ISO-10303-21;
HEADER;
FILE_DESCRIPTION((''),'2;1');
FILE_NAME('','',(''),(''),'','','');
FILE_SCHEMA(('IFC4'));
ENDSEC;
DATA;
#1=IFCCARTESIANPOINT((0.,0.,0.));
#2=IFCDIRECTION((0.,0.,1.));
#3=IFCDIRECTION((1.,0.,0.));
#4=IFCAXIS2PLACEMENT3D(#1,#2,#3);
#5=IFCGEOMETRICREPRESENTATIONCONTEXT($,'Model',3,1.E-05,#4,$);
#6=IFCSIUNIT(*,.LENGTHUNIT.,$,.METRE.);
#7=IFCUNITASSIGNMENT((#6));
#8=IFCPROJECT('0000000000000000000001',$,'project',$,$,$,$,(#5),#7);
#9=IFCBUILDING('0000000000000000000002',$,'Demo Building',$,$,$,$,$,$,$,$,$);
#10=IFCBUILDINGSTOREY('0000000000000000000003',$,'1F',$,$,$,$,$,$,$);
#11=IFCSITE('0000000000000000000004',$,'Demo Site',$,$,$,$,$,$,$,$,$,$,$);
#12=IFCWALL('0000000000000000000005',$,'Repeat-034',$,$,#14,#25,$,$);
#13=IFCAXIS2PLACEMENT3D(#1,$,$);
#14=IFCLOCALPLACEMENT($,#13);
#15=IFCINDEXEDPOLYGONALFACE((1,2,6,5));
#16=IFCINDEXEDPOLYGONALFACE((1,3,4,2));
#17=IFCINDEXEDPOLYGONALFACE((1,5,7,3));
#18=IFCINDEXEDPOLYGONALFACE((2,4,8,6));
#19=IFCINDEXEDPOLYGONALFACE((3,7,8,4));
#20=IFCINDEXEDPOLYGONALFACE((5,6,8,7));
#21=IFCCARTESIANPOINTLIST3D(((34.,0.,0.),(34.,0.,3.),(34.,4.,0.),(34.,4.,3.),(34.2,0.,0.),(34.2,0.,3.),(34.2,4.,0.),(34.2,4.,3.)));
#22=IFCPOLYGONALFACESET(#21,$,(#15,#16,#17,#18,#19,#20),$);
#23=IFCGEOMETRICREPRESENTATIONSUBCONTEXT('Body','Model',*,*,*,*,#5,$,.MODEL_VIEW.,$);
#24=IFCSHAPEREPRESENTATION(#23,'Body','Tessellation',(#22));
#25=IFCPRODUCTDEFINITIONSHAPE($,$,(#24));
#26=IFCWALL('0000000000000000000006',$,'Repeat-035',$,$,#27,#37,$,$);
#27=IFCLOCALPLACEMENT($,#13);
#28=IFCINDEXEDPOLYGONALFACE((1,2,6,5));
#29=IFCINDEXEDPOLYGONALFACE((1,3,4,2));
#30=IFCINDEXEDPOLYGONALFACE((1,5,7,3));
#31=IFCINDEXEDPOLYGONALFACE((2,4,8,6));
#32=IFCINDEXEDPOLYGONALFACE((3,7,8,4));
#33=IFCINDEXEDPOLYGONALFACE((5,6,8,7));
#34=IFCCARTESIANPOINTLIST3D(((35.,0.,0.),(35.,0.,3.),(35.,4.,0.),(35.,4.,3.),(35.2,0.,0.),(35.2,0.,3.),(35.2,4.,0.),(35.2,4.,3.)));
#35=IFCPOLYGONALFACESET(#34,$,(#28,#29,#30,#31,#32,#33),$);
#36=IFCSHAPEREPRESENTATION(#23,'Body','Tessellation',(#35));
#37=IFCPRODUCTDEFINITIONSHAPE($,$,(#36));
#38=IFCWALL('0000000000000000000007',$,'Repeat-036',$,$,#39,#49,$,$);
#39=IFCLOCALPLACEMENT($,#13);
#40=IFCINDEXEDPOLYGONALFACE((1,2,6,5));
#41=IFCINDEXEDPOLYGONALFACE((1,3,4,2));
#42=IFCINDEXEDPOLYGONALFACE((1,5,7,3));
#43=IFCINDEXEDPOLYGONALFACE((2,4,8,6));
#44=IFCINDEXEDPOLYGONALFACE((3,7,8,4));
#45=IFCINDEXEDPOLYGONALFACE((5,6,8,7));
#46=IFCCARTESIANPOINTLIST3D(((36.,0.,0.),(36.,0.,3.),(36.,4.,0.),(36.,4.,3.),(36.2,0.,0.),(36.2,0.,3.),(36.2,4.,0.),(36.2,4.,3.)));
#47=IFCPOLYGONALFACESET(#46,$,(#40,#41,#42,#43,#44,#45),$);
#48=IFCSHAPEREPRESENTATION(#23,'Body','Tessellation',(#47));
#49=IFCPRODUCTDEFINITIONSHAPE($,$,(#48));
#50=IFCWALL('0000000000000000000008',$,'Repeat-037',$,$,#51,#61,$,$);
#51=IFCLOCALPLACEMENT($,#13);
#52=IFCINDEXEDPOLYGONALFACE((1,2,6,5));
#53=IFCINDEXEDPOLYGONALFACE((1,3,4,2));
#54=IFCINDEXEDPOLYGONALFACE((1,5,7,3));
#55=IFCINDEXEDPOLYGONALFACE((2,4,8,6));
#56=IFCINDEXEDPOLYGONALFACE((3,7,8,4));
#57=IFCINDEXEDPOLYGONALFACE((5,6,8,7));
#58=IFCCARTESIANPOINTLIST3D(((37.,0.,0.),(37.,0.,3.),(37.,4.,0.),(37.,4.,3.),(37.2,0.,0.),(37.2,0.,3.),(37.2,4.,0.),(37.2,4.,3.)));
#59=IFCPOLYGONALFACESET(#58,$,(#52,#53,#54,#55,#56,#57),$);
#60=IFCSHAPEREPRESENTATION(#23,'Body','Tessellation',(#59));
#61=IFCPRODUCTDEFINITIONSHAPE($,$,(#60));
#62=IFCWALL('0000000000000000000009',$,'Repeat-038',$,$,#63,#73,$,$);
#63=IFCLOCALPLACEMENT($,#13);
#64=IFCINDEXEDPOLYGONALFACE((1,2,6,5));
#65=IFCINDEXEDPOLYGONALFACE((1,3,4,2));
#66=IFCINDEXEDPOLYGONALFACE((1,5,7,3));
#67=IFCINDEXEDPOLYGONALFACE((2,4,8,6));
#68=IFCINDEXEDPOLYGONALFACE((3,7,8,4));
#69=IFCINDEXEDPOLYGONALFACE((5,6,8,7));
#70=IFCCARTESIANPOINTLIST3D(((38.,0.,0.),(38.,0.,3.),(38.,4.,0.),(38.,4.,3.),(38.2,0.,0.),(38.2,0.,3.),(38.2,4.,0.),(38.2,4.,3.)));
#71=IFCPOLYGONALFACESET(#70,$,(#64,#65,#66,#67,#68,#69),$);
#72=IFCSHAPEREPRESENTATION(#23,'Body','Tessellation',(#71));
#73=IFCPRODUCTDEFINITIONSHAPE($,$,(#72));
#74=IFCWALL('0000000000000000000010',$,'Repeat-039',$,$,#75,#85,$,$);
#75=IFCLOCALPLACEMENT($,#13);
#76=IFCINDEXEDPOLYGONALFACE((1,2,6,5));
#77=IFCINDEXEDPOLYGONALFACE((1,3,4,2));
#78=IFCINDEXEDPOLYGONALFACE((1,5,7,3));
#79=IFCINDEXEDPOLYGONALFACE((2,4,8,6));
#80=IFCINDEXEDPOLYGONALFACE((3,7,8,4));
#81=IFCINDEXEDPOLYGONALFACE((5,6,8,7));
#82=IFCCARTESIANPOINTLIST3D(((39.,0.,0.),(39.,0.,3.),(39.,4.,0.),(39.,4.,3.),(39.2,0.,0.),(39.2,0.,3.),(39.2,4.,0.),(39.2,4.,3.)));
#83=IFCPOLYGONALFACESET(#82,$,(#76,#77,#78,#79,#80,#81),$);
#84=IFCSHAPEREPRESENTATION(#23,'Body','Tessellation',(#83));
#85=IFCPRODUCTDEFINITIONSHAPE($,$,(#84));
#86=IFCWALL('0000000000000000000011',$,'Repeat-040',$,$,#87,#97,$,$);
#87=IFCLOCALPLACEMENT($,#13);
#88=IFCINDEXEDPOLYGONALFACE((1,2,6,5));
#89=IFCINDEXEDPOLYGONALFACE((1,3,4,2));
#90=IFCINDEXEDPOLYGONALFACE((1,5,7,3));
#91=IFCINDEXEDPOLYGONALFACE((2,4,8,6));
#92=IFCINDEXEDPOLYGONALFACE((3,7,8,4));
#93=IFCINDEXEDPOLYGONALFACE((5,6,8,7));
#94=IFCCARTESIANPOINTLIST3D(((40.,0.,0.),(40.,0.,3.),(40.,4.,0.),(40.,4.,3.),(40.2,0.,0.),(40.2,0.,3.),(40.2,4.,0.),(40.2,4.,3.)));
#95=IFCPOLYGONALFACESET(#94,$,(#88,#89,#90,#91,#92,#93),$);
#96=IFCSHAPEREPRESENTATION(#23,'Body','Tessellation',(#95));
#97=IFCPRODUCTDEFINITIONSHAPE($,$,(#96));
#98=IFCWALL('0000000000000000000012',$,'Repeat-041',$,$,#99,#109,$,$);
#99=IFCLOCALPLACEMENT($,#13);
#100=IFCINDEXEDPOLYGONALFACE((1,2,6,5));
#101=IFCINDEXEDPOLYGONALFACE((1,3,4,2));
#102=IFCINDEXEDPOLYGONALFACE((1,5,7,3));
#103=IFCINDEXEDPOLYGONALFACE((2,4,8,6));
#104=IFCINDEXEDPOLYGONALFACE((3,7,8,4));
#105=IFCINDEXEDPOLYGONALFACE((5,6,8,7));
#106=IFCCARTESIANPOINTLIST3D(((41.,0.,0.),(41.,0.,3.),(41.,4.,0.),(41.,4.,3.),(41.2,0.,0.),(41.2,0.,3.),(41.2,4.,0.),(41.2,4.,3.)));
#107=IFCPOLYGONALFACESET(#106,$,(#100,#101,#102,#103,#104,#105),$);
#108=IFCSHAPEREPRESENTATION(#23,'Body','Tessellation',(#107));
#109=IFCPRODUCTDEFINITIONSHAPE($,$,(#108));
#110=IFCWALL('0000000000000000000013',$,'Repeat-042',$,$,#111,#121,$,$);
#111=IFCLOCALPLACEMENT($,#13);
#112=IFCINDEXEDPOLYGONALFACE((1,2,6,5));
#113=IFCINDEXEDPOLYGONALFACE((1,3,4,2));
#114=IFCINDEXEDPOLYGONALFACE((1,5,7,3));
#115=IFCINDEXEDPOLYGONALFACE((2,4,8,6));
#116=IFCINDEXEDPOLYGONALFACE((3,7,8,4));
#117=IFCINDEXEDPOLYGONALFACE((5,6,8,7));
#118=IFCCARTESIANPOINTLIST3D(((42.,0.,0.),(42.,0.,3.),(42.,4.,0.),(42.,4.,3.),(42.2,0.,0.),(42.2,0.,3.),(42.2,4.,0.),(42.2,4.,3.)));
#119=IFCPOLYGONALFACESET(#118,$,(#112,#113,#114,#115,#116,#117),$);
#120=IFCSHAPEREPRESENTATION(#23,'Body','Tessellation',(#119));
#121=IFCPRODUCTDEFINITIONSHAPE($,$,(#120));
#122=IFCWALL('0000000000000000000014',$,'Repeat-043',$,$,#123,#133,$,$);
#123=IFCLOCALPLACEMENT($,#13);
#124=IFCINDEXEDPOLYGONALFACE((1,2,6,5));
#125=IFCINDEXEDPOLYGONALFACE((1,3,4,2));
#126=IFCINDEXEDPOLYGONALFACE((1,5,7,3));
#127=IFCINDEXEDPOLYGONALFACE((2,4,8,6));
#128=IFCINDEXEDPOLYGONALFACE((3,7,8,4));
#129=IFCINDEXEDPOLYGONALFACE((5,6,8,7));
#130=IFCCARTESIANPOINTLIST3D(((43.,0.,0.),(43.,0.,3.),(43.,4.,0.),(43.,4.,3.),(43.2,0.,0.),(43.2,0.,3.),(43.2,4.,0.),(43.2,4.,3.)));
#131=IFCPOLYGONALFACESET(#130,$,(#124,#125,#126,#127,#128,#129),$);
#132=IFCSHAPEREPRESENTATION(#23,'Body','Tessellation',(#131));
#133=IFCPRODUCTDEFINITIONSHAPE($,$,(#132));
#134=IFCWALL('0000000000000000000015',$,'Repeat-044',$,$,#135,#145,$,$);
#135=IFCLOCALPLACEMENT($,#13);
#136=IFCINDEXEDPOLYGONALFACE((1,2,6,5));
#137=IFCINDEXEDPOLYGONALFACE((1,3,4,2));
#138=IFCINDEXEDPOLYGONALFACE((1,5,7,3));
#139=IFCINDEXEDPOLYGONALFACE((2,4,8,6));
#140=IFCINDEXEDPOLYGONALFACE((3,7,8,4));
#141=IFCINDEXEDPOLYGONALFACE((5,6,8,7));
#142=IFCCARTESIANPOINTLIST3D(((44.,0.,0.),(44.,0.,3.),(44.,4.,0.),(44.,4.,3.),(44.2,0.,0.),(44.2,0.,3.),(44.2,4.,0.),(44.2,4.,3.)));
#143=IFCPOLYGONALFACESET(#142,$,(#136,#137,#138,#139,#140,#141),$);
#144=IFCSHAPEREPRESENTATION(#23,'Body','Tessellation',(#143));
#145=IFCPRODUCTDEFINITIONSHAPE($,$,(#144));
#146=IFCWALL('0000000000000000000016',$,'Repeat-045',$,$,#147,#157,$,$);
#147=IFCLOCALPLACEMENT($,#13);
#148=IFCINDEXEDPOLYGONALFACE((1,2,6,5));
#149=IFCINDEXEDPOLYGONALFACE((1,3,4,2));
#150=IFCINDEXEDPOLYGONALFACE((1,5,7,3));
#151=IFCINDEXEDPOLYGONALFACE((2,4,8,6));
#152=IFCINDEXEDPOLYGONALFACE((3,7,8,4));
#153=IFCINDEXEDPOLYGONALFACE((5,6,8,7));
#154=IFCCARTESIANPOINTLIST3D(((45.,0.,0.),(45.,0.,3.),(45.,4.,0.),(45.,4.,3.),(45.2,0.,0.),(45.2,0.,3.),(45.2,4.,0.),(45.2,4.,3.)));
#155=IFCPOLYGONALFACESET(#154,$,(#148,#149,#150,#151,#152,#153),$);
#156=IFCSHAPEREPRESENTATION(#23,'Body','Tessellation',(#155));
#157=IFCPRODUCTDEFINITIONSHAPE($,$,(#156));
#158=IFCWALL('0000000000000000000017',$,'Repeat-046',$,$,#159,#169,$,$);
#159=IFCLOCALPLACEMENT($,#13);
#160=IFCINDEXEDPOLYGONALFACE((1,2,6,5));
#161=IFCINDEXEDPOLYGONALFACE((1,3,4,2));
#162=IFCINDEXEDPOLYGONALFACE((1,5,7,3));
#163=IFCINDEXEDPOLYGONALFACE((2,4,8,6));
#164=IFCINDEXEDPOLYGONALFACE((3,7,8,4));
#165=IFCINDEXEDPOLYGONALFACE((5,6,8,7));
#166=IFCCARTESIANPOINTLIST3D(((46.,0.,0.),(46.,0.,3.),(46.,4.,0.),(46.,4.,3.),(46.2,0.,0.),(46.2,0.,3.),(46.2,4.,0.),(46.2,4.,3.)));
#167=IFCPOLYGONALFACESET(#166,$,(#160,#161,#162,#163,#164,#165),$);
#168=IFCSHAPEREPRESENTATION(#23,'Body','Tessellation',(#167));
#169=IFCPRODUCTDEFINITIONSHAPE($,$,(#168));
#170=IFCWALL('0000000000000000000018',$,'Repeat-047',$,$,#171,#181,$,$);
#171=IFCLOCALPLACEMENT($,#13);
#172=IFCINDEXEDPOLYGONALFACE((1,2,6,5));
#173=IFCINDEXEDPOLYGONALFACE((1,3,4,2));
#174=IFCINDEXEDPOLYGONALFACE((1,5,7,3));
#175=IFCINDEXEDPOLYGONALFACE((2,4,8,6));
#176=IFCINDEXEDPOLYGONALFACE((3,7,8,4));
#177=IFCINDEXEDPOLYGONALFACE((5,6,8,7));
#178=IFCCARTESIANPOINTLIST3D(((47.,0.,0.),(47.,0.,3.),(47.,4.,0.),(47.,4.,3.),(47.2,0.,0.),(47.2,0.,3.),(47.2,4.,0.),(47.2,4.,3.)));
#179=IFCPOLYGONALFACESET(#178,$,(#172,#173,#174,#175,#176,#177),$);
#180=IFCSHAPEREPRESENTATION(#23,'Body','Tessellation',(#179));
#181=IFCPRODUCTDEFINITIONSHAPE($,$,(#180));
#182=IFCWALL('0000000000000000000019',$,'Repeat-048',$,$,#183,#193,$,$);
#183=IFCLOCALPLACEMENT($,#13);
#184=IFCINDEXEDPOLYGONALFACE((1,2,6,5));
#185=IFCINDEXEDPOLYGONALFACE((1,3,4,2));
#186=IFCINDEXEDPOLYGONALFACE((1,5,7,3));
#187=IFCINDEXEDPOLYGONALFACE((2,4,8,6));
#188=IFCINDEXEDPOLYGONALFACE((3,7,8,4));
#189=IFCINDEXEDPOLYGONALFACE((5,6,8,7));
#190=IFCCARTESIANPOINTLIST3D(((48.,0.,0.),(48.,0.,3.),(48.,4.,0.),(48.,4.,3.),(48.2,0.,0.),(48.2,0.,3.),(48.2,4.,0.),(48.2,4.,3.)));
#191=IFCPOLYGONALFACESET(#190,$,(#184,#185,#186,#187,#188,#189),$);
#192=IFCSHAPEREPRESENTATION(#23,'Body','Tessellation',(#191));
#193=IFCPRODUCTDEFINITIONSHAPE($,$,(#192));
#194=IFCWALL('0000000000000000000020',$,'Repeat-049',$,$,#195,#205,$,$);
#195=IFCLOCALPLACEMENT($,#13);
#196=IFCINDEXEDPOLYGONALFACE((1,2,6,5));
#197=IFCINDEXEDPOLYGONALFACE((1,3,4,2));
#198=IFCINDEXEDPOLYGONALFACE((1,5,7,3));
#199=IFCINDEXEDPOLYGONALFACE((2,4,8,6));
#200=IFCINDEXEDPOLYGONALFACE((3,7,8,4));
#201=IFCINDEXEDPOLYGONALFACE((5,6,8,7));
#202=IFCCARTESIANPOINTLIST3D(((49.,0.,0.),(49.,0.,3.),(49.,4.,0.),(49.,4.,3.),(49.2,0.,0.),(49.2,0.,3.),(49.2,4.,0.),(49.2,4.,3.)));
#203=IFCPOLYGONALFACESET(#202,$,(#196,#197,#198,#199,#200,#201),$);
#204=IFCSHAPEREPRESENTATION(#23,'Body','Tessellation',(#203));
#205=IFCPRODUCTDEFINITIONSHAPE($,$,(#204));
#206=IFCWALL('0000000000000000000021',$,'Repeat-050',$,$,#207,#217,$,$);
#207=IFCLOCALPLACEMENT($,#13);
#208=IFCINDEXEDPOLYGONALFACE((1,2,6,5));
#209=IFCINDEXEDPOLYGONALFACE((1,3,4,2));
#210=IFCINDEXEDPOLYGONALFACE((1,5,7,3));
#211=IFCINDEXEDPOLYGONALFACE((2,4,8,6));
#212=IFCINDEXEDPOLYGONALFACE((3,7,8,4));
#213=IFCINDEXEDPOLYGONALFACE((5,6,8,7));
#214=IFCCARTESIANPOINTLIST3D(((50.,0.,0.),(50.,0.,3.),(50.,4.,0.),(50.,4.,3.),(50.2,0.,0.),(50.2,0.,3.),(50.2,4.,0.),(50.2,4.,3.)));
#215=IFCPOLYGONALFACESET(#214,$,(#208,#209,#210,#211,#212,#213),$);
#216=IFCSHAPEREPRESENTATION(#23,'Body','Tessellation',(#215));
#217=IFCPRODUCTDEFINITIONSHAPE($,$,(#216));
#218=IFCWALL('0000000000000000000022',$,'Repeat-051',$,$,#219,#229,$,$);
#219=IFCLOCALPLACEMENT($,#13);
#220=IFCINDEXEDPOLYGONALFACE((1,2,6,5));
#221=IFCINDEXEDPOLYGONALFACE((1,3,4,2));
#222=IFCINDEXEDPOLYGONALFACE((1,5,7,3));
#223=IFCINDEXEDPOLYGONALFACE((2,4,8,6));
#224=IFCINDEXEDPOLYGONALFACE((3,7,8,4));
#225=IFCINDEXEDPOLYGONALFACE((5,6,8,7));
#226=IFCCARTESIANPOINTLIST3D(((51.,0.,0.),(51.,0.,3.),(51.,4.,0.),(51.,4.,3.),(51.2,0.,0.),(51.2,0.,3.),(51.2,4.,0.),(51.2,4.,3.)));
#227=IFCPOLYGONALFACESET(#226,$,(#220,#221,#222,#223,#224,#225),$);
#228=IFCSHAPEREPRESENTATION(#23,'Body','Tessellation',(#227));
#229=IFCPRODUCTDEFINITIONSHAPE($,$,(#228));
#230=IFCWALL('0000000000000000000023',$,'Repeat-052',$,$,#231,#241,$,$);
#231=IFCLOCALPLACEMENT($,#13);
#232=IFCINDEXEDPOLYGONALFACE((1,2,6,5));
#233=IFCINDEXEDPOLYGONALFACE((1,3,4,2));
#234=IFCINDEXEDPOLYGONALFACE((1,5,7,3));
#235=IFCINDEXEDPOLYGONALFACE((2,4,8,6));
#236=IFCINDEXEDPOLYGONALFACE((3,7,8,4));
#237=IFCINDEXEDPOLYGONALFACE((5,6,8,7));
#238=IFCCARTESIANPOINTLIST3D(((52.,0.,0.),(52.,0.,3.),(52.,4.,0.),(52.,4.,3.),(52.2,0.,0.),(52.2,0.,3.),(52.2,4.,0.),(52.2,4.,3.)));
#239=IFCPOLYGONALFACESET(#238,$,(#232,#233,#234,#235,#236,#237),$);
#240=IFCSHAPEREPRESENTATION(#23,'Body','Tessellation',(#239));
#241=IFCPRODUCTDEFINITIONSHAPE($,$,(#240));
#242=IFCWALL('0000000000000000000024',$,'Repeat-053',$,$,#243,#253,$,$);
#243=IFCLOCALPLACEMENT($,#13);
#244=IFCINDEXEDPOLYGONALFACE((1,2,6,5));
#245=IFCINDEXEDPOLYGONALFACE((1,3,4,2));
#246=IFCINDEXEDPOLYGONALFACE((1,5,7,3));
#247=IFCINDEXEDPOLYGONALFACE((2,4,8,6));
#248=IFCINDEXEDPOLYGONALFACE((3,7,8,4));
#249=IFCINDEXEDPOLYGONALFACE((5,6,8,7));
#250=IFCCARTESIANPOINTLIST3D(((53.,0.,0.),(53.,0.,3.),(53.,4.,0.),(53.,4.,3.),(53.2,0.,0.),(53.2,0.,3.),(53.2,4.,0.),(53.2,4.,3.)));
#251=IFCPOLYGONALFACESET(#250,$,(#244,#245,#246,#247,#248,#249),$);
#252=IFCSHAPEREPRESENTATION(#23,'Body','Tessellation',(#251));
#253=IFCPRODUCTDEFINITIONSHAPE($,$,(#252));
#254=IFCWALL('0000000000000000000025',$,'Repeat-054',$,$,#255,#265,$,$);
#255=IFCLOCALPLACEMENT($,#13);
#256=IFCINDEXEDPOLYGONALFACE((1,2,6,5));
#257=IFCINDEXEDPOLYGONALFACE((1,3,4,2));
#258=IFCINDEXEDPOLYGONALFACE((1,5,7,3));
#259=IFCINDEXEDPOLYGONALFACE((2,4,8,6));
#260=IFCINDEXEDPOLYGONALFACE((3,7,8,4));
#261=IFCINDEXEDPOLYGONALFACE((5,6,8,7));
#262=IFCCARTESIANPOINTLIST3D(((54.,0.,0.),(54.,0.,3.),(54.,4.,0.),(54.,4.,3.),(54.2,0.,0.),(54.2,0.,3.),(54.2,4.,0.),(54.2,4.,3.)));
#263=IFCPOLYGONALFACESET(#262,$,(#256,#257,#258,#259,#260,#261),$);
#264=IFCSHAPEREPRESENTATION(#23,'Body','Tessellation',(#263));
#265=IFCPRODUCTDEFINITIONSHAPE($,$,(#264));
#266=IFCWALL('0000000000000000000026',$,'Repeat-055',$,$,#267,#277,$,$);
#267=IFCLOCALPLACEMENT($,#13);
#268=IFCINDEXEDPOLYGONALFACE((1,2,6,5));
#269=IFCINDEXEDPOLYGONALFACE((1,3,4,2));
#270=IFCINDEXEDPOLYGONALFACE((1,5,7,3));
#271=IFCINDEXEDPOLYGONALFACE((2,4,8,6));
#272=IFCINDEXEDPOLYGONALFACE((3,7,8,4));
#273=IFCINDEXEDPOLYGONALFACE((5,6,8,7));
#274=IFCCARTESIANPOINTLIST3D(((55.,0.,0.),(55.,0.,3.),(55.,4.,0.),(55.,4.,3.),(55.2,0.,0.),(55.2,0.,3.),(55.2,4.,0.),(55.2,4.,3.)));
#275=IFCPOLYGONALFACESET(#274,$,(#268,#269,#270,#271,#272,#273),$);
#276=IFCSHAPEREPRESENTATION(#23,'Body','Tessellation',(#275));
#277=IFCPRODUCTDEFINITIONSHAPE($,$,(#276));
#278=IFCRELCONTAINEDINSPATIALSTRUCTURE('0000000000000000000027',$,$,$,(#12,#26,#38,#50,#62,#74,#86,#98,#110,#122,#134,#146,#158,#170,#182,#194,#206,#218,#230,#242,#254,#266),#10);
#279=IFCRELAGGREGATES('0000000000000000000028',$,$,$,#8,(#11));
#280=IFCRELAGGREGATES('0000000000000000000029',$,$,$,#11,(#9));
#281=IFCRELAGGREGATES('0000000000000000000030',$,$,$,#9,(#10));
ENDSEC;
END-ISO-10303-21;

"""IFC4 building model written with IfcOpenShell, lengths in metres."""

from ifc_helpers import new_model, entity, si_unit, frame, origin_with_axes, place, context, subcontext, project, spatial, element, save


model = new_model("IFC4")

# Units and contexts
model_context = context("Model", 3, precision=1e-05, world=origin_with_axes())
body_context = subcontext(model_context, "Body", "Model", "MODEL_VIEW")
ifc_project = project(units=[si_unit("LENGTHUNIT", "METRE")], contexts=[model_context])

# Site, building, storey
site = spatial("IfcSite", under=ifc_project, Name="Demo Site")
building = spatial("IfcBuilding", under=site, Name="Demo Building")
storey = spatial("IfcBuildingStorey", under=building, Name="1F")

# Walls
for number, where, z_axis, x_axis, name in (
    (1, (34.0, 0.0, 0.0), (0.0, 0.0, 1.0), (1.0, 0.0, 0.0), "Repeat-034"),
    (2, (35.0, 0.0, 0.0), (0.0, 0.0, 1.0), (1.0, 0.0, 0.0), "Repeat-035"),
    (3, (36.0, 0.0, 0.0), (0.0, 0.0, 1.0), (1.0, 0.0, 0.0), "Repeat-036"),
    (4, (37.0, 0.0, 0.0), (0.0, 0.0, 1.0), (1.0, 0.0, 0.0), "Repeat-037"),
    (5, (38.0, 0.0, 0.0), (0.0, 0.0, 1.0), (1.0, 0.0, 0.0), "Repeat-038"),
    (6, (39.0, 0.0, 0.0), (0.0, 0.0, 1.0), (1.0, 0.0, 0.0), "Repeat-039"),
    (7, (40.0, 0.0, 0.0), (0.0, 0.0, 1.0), (1.0, 0.0, 0.0), "Repeat-040"),
    (8, (41.0, 0.0, 0.0), (0.0, 0.0, 1.0), (1.0, 0.0, 0.0), "Repeat-041"),
    (9, (42.0, 0.0, 0.0), (0.0, 0.0, 1.0), (1.0, 0.0, 0.0), "Repeat-042"),
    (10, (43.0, 0.0, 0.0), (0.0, 0.0, 1.0), (1.0, 0.0, 0.0), "Repeat-043"),
    (11, (44.0, 0.0, 0.0), (0.0, 0.0, 1.0), (1.0, 0.0, 0.0), "Repeat-044"),
    (12, (45.0, 0.0, 0.0), (0.0, 0.0, 1.0), (1.0, 0.0, 0.0), "Repeat-045"),
    (13, (46.0, 0.0, 0.0), (0.0, 0.0, 1.0), (1.0, 0.0, 0.0), "Repeat-046"),
    (14, (47.0, 0.0, 0.0), (0.0, 0.0, 1.0), (1.0, 0.0, 0.0), "Repeat-047"),
    (15, (48.0, 0.0, 0.0), (0.0, 0.0, 1.0), (1.0, 0.0, 0.0), "Repeat-048"),
    (16, (49.0, 0.0, 0.0), (0.0, 0.0, 1.0), (1.0, 0.0, 0.0), "Repeat-049"),
    (17, (50.0, 0.0, 0.0), (0.0, 0.0, 1.0), (1.0, 0.0, 0.0), "Repeat-050"),
    (18, (51.0, 0.0, 0.0), (0.0, 0.0, 1.0), (1.0, 0.0, 0.0), "Repeat-051"),
    (19, (52.0, 0.0, 0.0), (0.0, 0.0, 1.0), (1.0, 0.0, 0.0), "Repeat-052"),
    (20, (53.0, 0.0, 0.0), (0.0, 0.0, 1.0), (1.0, 0.0, 0.0), "Repeat-053"),
    (21, (54.0, 0.0, 0.0), (0.0, 0.0, 1.0), (1.0, 0.0, 0.0), "Repeat-054"),
    (22, (55.0, 0.0, 0.0), (0.0, 0.0, 1.0), (1.0, 0.0, 0.0), "Repeat-055"),
):
    element("IfcWall", number, at=place(None, frame(where, z_axis=z_axis, x_axis=x_axis)), inside=storey, Name=name, context=body_context, shape_type="CSG", body=[
        entity("IfcBlock", entity("IfcAxis2Placement3D", entity("IfcCartesianPoint", [0.0, 0.0, 0.0]), entity("IfcDirection", [0.0, 0.0, 1.0]), entity("IfcDirection", [1.0, 0.0, 0.0])), 0.2, 4.0, 3.0),
    ])

save(model, "model.ifc")
